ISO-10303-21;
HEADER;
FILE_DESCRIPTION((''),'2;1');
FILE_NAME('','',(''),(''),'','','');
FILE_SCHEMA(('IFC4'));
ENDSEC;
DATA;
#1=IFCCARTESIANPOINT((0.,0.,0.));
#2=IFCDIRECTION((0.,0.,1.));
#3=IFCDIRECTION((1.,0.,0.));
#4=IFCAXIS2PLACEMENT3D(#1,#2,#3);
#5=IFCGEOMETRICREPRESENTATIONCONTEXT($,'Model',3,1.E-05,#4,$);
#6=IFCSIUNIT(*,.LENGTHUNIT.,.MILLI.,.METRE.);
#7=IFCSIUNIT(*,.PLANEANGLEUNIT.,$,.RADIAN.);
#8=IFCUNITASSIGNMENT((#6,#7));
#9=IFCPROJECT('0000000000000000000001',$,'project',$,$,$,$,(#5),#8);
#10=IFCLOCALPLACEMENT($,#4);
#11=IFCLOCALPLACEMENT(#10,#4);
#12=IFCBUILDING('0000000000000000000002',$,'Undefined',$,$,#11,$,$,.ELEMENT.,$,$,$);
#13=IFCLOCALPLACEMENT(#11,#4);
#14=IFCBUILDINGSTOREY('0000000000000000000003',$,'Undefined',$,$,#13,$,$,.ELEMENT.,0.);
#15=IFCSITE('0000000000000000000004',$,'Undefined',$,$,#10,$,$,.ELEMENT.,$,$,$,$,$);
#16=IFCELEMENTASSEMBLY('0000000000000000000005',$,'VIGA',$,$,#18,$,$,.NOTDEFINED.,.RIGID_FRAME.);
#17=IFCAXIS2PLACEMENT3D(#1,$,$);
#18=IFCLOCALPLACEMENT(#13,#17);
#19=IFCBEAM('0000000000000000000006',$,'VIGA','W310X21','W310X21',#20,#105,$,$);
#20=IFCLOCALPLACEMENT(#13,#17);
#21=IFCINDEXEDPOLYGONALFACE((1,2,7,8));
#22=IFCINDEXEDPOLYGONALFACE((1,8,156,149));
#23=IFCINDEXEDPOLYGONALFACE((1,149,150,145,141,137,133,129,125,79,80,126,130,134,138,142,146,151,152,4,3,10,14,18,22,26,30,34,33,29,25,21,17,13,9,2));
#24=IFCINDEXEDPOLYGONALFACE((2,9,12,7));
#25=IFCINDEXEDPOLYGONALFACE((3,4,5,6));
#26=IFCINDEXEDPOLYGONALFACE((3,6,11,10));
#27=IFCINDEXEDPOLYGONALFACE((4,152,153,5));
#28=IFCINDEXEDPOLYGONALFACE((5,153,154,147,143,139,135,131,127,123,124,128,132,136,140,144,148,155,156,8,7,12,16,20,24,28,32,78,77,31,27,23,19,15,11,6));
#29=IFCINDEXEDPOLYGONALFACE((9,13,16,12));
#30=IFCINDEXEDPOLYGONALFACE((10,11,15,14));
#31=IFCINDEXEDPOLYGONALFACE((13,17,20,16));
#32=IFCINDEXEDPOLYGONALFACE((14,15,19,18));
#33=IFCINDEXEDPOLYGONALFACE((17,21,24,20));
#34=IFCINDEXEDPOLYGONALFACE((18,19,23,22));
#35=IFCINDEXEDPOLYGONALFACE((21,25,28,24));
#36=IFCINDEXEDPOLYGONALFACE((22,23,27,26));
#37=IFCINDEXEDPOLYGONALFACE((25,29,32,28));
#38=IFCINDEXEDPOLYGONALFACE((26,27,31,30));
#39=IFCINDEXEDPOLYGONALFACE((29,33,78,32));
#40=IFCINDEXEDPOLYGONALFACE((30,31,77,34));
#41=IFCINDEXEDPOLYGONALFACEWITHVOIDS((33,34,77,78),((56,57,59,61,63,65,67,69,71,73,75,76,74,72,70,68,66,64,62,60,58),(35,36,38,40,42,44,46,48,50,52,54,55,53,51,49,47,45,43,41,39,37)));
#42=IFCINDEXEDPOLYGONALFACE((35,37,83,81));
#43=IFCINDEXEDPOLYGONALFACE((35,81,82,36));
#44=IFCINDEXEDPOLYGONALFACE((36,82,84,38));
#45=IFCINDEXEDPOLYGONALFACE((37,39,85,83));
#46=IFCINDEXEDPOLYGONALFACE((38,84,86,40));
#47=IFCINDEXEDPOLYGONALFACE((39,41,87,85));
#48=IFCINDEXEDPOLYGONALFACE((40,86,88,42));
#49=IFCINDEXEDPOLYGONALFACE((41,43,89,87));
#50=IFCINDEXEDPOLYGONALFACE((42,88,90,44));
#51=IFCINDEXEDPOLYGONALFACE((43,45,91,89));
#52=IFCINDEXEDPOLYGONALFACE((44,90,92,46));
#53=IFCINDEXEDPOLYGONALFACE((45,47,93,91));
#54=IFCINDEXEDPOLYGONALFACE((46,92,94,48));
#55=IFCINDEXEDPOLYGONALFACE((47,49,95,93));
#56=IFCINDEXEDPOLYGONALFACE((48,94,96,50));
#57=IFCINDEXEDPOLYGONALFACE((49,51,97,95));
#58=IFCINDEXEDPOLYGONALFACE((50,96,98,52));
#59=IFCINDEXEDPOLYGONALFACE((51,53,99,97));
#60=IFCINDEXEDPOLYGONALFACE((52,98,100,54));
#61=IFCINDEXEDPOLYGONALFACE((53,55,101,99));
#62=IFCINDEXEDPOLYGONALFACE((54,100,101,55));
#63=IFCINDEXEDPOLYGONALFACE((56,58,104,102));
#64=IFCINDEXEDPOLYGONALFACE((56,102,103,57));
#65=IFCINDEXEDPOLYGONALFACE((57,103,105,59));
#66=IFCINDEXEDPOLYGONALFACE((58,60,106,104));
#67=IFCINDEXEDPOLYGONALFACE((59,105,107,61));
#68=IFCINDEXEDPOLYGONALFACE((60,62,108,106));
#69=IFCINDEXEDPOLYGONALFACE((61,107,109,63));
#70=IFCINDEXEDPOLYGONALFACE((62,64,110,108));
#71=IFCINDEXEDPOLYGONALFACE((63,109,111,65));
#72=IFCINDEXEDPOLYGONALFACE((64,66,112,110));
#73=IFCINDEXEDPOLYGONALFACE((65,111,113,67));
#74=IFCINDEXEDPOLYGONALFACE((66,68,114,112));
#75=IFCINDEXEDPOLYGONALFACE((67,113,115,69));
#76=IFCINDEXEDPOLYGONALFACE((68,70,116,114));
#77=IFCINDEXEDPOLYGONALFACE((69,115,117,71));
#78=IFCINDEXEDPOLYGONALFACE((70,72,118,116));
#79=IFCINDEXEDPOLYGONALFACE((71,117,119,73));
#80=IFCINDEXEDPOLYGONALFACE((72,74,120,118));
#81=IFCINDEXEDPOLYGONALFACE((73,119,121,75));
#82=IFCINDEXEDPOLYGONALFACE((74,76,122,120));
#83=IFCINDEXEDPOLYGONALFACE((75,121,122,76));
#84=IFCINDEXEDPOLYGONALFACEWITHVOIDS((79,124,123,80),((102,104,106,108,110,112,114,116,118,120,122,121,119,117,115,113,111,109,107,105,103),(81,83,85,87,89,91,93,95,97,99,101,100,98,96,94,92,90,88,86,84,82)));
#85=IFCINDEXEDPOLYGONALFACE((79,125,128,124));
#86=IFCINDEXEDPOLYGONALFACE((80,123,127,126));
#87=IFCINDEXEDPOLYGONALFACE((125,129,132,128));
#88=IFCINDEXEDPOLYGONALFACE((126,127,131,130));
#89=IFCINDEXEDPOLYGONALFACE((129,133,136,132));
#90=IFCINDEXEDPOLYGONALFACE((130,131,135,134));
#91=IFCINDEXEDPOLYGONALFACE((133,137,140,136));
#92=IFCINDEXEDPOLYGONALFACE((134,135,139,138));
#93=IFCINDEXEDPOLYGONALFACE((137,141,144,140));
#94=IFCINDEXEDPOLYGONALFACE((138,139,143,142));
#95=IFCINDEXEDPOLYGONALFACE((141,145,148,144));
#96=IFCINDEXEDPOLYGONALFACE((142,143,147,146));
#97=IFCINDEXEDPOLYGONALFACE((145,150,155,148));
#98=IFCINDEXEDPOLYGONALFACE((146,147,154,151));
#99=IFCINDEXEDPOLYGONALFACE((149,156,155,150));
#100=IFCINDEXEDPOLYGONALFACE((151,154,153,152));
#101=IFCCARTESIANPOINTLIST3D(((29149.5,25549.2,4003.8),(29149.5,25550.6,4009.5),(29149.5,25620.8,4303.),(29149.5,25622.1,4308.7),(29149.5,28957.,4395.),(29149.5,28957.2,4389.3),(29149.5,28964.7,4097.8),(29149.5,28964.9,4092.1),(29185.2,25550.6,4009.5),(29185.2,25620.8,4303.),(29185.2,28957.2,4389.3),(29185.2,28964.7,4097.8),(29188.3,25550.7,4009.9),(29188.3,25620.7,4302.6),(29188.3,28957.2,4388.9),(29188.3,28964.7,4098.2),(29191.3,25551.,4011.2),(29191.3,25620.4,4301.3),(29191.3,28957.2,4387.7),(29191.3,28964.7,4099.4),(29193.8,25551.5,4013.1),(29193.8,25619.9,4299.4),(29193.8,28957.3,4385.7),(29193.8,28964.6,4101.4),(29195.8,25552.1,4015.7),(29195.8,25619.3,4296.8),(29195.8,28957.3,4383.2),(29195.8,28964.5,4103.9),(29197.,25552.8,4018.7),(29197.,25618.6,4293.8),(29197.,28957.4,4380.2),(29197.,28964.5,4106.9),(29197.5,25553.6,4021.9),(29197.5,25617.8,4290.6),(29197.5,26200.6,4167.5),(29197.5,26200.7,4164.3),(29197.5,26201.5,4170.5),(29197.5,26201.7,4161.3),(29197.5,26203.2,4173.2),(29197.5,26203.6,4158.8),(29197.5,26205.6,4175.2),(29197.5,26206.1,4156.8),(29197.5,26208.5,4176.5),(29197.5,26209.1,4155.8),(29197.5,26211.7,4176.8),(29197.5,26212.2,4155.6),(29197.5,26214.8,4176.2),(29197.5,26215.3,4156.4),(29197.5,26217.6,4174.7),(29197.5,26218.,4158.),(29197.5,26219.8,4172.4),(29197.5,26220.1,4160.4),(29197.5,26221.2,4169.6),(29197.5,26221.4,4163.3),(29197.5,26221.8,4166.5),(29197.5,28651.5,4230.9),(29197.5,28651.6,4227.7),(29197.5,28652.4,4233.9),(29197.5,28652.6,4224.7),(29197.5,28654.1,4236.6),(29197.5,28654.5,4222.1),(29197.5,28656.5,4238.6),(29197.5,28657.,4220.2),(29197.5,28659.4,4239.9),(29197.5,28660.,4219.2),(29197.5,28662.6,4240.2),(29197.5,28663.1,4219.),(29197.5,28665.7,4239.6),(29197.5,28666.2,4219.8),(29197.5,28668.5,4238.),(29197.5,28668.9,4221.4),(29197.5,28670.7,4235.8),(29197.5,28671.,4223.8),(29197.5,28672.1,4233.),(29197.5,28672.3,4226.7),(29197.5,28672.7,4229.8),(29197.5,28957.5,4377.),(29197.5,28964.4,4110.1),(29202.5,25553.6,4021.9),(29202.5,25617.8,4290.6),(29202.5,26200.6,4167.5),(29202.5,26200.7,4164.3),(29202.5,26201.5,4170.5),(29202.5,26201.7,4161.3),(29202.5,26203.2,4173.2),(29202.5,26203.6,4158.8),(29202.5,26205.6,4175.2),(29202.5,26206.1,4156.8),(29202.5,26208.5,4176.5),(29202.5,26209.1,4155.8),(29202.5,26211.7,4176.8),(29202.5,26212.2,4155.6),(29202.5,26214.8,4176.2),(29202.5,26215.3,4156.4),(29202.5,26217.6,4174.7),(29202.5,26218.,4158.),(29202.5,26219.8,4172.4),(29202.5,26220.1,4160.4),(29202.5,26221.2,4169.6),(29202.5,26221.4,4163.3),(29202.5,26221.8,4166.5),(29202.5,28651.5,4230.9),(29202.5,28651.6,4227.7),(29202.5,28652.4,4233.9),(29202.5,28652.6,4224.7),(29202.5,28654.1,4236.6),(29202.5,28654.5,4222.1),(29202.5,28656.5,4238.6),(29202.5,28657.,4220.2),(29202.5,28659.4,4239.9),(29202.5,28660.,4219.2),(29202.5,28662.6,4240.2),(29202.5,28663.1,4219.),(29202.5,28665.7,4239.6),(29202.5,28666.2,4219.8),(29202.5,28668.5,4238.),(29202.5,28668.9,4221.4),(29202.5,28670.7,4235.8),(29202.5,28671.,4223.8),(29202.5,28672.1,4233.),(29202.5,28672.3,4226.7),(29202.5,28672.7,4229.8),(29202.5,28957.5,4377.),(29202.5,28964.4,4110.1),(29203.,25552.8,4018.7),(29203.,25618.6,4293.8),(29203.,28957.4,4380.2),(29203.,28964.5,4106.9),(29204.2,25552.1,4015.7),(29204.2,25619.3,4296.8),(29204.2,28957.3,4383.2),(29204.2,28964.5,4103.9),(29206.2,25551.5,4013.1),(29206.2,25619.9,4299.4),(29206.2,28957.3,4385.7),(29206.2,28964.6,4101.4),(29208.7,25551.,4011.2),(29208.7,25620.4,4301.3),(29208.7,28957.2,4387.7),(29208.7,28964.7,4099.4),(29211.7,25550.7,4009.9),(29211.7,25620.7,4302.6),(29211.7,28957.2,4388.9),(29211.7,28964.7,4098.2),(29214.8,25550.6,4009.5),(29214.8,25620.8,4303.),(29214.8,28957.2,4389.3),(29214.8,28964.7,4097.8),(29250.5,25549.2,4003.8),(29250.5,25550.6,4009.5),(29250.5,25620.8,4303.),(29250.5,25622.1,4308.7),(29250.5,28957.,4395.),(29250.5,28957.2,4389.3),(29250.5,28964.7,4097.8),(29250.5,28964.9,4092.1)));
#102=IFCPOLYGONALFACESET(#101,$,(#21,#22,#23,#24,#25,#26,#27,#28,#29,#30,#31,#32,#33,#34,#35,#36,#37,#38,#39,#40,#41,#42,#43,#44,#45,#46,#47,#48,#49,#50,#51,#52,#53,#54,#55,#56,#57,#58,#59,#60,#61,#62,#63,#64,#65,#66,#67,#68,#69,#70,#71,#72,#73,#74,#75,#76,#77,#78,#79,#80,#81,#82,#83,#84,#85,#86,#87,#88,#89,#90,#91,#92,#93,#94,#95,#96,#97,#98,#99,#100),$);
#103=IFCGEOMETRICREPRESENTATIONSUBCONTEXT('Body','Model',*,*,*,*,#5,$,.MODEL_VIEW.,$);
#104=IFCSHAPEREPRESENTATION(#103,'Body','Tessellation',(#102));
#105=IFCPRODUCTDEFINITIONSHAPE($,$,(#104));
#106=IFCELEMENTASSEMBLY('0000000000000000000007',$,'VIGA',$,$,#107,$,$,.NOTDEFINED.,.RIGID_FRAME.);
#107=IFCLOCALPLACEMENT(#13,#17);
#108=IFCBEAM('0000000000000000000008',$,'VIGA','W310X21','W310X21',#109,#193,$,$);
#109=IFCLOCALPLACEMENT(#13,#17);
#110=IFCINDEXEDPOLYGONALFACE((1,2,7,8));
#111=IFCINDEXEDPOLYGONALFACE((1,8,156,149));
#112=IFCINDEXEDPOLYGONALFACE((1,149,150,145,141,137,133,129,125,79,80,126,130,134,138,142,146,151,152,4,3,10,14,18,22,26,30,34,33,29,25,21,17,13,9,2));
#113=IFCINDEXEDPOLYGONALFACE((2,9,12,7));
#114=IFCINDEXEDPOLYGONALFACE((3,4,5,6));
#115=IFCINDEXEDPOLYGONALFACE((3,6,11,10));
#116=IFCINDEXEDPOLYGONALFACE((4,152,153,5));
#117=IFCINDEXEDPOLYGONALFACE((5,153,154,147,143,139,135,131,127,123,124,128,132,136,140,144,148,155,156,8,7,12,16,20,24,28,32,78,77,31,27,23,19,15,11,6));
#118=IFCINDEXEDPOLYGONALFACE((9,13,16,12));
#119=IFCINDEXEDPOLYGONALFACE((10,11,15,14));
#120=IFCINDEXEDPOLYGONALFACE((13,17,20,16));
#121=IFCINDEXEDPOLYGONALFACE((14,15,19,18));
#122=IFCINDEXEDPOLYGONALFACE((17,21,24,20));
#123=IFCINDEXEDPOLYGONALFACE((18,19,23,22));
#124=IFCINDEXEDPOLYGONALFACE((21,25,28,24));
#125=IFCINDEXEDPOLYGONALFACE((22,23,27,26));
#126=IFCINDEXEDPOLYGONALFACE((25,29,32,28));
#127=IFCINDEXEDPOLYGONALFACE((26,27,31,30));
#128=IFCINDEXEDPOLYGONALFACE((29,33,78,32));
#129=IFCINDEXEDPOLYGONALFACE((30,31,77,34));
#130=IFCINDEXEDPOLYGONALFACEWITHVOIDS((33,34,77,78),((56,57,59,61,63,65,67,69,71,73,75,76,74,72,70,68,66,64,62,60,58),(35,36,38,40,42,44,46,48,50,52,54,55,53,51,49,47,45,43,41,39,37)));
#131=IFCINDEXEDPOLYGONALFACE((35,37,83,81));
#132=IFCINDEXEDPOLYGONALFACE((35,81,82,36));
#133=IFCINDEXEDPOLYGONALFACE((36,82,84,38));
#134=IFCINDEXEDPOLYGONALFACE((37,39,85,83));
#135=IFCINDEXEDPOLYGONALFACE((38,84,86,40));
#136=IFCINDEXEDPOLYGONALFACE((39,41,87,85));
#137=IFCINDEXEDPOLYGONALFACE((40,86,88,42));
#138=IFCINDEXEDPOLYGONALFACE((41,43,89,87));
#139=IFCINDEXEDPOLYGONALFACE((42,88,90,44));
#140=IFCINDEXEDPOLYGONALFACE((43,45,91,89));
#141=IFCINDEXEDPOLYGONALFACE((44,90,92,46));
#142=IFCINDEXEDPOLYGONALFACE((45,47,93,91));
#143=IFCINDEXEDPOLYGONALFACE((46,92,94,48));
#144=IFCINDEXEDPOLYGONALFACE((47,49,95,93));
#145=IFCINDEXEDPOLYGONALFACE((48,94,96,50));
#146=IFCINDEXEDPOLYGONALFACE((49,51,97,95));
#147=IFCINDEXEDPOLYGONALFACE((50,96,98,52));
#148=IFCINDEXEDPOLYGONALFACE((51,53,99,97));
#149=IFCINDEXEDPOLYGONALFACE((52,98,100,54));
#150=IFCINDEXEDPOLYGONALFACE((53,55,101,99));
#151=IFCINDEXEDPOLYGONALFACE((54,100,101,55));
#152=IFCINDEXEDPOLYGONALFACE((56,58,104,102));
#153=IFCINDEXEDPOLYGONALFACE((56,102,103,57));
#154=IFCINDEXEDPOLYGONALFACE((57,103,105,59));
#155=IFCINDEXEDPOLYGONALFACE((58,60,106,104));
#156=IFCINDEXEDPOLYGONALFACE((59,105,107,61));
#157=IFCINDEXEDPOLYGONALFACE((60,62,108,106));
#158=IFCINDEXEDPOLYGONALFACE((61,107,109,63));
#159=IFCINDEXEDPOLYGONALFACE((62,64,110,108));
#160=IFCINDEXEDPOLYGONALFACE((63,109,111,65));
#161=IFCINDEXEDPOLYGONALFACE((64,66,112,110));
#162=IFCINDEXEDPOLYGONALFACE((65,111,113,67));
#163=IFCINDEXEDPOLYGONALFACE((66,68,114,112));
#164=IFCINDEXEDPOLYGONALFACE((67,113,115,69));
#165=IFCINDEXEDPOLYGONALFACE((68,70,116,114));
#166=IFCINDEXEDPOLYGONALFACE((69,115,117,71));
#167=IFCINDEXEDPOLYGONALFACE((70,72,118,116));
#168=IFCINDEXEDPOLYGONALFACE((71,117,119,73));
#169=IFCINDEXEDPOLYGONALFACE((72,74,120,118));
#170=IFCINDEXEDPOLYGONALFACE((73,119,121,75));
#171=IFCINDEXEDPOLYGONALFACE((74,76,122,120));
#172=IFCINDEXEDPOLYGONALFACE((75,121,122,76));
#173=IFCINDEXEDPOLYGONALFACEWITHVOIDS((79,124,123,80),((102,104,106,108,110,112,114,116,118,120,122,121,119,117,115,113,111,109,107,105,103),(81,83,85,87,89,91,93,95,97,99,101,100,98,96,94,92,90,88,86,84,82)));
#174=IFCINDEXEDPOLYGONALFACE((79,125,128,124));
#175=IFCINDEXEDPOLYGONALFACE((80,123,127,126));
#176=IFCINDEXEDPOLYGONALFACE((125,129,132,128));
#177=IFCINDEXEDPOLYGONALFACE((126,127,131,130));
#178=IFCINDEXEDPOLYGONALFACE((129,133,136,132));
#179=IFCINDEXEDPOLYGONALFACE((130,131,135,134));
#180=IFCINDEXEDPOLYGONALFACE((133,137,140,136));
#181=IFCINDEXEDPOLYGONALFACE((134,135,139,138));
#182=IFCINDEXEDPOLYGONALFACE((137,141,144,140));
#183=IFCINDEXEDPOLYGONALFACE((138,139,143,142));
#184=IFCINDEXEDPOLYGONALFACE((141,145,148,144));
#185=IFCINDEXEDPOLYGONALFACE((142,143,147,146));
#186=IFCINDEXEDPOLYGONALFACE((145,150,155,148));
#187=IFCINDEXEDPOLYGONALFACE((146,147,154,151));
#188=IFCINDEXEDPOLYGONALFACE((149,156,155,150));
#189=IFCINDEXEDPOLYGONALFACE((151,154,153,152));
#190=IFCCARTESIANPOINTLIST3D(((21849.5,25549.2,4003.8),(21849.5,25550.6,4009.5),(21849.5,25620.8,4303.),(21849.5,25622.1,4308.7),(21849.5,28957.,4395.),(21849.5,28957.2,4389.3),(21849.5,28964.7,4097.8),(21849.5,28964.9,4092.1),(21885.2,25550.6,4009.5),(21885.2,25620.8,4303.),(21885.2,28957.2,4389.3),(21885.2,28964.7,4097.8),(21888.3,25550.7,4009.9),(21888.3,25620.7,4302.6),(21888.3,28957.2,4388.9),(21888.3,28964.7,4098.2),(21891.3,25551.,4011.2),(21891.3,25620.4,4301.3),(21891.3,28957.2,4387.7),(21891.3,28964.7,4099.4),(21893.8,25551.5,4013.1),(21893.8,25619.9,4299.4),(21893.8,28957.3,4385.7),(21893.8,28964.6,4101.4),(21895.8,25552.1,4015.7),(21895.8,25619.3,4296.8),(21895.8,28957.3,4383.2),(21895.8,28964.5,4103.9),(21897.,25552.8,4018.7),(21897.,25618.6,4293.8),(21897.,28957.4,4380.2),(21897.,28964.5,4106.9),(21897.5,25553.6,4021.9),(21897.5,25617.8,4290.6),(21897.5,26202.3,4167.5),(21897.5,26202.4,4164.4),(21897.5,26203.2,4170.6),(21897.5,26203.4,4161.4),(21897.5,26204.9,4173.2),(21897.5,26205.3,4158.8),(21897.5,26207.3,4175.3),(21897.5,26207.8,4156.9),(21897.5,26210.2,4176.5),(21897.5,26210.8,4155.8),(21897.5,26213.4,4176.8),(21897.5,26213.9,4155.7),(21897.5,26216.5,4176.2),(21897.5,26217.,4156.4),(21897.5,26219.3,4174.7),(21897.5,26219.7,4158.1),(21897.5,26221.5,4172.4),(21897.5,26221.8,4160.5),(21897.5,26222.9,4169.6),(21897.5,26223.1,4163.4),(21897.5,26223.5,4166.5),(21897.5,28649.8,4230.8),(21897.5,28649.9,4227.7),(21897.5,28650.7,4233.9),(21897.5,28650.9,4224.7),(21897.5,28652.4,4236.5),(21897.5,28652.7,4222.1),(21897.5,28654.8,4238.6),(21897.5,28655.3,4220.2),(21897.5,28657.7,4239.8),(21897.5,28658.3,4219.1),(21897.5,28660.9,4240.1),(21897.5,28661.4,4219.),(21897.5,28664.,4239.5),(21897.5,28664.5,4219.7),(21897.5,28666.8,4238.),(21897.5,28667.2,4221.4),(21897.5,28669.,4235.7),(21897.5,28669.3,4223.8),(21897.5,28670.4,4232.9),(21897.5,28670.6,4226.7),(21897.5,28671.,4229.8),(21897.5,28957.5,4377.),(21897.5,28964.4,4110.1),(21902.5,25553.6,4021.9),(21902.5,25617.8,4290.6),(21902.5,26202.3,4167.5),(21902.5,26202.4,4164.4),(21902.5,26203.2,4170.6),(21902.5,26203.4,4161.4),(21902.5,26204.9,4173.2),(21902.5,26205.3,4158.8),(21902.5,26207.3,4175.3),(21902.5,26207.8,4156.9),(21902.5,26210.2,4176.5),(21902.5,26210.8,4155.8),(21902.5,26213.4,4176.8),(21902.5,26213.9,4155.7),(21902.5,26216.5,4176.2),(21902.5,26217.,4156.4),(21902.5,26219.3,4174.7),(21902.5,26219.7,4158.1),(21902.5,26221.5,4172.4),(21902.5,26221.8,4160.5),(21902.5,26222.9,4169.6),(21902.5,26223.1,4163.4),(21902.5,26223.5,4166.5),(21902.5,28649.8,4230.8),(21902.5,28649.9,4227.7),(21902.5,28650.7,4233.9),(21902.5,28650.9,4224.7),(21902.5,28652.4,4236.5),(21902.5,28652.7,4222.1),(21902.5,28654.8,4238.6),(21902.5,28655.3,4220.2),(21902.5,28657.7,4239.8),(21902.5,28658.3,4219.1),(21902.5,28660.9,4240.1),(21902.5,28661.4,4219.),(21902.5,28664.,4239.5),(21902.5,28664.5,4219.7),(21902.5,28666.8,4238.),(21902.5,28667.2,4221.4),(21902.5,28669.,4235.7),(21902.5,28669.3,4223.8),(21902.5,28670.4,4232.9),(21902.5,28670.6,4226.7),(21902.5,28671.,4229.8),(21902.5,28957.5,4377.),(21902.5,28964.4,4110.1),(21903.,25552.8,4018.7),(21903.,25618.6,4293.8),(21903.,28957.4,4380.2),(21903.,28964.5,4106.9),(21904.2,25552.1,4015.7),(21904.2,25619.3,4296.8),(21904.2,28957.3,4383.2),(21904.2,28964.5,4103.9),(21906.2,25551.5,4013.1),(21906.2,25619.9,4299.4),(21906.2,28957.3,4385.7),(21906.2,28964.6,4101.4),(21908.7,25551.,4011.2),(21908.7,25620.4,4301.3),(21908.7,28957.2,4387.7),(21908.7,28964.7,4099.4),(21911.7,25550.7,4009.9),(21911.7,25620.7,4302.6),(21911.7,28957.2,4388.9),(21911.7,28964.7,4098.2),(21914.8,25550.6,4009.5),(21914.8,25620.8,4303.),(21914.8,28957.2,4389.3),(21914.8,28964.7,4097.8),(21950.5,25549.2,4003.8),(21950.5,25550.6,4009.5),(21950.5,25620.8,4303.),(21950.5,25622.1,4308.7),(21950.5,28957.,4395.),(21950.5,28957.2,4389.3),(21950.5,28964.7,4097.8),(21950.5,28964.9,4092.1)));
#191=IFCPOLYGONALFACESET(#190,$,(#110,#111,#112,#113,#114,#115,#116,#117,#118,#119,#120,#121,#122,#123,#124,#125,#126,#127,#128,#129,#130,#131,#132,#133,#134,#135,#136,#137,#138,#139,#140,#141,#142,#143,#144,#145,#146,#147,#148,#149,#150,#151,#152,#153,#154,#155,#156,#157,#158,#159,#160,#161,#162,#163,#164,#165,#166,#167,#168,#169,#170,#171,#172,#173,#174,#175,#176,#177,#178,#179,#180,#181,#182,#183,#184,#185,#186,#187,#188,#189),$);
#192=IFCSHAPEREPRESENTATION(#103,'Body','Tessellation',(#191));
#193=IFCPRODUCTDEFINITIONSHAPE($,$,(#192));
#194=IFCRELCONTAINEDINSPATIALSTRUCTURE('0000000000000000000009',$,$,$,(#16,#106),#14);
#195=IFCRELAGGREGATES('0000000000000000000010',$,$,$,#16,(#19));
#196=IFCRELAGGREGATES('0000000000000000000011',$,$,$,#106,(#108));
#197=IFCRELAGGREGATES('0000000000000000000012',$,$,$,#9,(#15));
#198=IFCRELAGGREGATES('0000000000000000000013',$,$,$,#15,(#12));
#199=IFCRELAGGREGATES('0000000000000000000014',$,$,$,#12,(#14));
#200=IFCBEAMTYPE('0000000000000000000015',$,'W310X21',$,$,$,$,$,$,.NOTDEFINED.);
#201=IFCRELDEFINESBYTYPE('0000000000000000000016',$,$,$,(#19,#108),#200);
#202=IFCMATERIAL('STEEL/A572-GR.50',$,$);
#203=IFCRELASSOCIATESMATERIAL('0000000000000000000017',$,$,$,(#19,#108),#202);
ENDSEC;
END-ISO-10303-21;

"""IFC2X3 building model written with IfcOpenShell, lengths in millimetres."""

from ifc_helpers import new_model, si_unit, frame, origin_with_axes, origin_2d_with_axis, place, context, subcontext, project, spatial, circle, i_section, extrude, boolean, halfspace, material, type_object, element, aggregate, save


model = new_model("IFC2X3")

# Units and contexts
model_context = context("Model", 3, precision=1e-05, world=origin_with_axes())
body_context = subcontext(model_context, "Body", "Model", "MODEL_VIEW")
ifc_project = project(units=[si_unit("LENGTHUNIT", "METRE", prefix="MILLI"), si_unit("PLANEANGLEUNIT", "RADIAN")], contexts=[model_context])

# Site, building, storey
site_placement = place(None, origin_with_axes())
site = spatial("IfcSite", under=ifc_project, at=site_placement, Name="Undefined", CompositionType="ELEMENT")
building_placement = place(site_placement, origin_with_axes())
building = spatial("IfcBuilding", under=site, at=building_placement, Name="Undefined", CompositionType="ELEMENT")
storey_placement = place(building_placement, origin_with_axes())
storey = spatial("IfcBuildingStorey", under=building, at=storey_placement, Name="Undefined", CompositionType="ELEMENT", Elevation=0.0)

# Element assemblies, beams
ifc_material_1 = material(Name="STEEL/A572-GR.50")
assembly_1_placement = place(storey_placement, origin_with_axes())
assembly_1 = element("IfcElementAssembly", 1, at=assembly_1_placement, inside=storey, Name="VIGA", AssemblyPlace="NOTDEFINED", PredefinedType="RIGID_FRAME")
beam_type_1 = type_object("IfcBeamType", Name="W310X21", PredefinedType="NOTDEFINED")
beam_1_placement = place(assembly_1_placement, frame((29200.0, 25403.9, 4151.6), z_axis=(0.0, -0.025855, 0.999666), x_axis=(0.0, 0.999666, 0.025855)))
beam_1 = element("IfcBeam", 2, at=beam_1_placement, type_object=beam_type_1, material=ifc_material_1, Name="VIGA", Description="W310X21", ObjectType="W310X21", context=body_context, shape_type="CSG", body=[
    boolean("DIFFERENCE", boolean("DIFFERENCE", boolean("DIFFERENCE", extrude(i_section(OverallWidth=101.0, OverallDepth=303.0, WebThickness=5.1, FlangeThickness=5.7, FilletRadius=12.3, at=origin_2d_with_axis()), frame((3558.2, 0.0, 0.0), z_axis=(-1.0, 0.0, 0.0), x_axis=(0.0, -1.0, 0.0)), (0.0, 0.0, 1.0), 3558.2), extrude(circle(Radius=10.6, at=origin_2d_with_axis()), frame((3259.1, -100.0, -6.3), z_axis=(0.0, 1.0, 0.0), x_axis=(1.0, 0.0, 0.0)), (0.0, 0.0, 1.0), 200.0)), extrude(circle(Radius=10.6, at=origin_2d_with_axis()), frame((807.4, -100.0, -6.2), z_axis=(0.0, 1.0, 0.0), x_axis=(1.0, 0.0, 0.0)), (0.0, 0.0, 1.0), 200.0)), halfspace(frame((141.4, -50.5, -151.7), z_axis=(-0.966259, 0.0, 0.257573), x_axis=(0.0, 1.0, 0.0)), False)),
])
aggregate(assembly_1, [beam_1])
assembly_2_placement = place(storey_placement, origin_with_axes())
assembly_2 = element("IfcElementAssembly", 3, at=assembly_2_placement, inside=storey, Name="VIGA", AssemblyPlace="NOTDEFINED", PredefinedType="RIGID_FRAME")
beam_2_placement = place(assembly_2_placement, frame((21900.0, 25403.9, 4151.6), z_axis=(0.0, -0.025855, 0.999666), x_axis=(0.0, 0.999666, 0.025855)))
beam_2 = element("IfcBeam", 4, at=beam_2_placement, type_object=beam_type_1, material=ifc_material_1, Name="VIGA", Description="W310X21", ObjectType="W310X21", context=body_context, shape_type="CSG", body=[
    boolean("DIFFERENCE", boolean("DIFFERENCE", boolean("DIFFERENCE", extrude(i_section(OverallWidth=101.0, OverallDepth=303.0, WebThickness=5.1, FlangeThickness=5.7, FilletRadius=12.3, at=origin_2d_with_axis()), frame((3558.2, 0.0, 0.0), z_axis=(-1.0, 0.0, 0.0), x_axis=(0.0, -1.0, 0.0)), (0.0, 0.0, 1.0), 3558.2), extrude(circle(Radius=10.6, at=origin_2d_with_axis()), frame((809.1, 100.0, -6.3), z_axis=(0.0, -1.0, 0.0), x_axis=(1.0, 0.0, 0.0)), (0.0, 0.0, 1.0), 200.0)), extrude(circle(Radius=10.6, at=origin_2d_with_axis()), frame((3257.4, 100.0, -6.3), z_axis=(0.0, -1.0, 0.0), x_axis=(1.0, 0.0, 0.0)), (0.0, 0.0, 1.0), 200.0)), halfspace(frame((141.4, -50.5, -151.7), z_axis=(-0.966259, 0.0, 0.257573), x_axis=(0.0, 1.0, 0.0)), False)),
])
aggregate(assembly_2, [beam_2])

save(model, "model.ifc")
